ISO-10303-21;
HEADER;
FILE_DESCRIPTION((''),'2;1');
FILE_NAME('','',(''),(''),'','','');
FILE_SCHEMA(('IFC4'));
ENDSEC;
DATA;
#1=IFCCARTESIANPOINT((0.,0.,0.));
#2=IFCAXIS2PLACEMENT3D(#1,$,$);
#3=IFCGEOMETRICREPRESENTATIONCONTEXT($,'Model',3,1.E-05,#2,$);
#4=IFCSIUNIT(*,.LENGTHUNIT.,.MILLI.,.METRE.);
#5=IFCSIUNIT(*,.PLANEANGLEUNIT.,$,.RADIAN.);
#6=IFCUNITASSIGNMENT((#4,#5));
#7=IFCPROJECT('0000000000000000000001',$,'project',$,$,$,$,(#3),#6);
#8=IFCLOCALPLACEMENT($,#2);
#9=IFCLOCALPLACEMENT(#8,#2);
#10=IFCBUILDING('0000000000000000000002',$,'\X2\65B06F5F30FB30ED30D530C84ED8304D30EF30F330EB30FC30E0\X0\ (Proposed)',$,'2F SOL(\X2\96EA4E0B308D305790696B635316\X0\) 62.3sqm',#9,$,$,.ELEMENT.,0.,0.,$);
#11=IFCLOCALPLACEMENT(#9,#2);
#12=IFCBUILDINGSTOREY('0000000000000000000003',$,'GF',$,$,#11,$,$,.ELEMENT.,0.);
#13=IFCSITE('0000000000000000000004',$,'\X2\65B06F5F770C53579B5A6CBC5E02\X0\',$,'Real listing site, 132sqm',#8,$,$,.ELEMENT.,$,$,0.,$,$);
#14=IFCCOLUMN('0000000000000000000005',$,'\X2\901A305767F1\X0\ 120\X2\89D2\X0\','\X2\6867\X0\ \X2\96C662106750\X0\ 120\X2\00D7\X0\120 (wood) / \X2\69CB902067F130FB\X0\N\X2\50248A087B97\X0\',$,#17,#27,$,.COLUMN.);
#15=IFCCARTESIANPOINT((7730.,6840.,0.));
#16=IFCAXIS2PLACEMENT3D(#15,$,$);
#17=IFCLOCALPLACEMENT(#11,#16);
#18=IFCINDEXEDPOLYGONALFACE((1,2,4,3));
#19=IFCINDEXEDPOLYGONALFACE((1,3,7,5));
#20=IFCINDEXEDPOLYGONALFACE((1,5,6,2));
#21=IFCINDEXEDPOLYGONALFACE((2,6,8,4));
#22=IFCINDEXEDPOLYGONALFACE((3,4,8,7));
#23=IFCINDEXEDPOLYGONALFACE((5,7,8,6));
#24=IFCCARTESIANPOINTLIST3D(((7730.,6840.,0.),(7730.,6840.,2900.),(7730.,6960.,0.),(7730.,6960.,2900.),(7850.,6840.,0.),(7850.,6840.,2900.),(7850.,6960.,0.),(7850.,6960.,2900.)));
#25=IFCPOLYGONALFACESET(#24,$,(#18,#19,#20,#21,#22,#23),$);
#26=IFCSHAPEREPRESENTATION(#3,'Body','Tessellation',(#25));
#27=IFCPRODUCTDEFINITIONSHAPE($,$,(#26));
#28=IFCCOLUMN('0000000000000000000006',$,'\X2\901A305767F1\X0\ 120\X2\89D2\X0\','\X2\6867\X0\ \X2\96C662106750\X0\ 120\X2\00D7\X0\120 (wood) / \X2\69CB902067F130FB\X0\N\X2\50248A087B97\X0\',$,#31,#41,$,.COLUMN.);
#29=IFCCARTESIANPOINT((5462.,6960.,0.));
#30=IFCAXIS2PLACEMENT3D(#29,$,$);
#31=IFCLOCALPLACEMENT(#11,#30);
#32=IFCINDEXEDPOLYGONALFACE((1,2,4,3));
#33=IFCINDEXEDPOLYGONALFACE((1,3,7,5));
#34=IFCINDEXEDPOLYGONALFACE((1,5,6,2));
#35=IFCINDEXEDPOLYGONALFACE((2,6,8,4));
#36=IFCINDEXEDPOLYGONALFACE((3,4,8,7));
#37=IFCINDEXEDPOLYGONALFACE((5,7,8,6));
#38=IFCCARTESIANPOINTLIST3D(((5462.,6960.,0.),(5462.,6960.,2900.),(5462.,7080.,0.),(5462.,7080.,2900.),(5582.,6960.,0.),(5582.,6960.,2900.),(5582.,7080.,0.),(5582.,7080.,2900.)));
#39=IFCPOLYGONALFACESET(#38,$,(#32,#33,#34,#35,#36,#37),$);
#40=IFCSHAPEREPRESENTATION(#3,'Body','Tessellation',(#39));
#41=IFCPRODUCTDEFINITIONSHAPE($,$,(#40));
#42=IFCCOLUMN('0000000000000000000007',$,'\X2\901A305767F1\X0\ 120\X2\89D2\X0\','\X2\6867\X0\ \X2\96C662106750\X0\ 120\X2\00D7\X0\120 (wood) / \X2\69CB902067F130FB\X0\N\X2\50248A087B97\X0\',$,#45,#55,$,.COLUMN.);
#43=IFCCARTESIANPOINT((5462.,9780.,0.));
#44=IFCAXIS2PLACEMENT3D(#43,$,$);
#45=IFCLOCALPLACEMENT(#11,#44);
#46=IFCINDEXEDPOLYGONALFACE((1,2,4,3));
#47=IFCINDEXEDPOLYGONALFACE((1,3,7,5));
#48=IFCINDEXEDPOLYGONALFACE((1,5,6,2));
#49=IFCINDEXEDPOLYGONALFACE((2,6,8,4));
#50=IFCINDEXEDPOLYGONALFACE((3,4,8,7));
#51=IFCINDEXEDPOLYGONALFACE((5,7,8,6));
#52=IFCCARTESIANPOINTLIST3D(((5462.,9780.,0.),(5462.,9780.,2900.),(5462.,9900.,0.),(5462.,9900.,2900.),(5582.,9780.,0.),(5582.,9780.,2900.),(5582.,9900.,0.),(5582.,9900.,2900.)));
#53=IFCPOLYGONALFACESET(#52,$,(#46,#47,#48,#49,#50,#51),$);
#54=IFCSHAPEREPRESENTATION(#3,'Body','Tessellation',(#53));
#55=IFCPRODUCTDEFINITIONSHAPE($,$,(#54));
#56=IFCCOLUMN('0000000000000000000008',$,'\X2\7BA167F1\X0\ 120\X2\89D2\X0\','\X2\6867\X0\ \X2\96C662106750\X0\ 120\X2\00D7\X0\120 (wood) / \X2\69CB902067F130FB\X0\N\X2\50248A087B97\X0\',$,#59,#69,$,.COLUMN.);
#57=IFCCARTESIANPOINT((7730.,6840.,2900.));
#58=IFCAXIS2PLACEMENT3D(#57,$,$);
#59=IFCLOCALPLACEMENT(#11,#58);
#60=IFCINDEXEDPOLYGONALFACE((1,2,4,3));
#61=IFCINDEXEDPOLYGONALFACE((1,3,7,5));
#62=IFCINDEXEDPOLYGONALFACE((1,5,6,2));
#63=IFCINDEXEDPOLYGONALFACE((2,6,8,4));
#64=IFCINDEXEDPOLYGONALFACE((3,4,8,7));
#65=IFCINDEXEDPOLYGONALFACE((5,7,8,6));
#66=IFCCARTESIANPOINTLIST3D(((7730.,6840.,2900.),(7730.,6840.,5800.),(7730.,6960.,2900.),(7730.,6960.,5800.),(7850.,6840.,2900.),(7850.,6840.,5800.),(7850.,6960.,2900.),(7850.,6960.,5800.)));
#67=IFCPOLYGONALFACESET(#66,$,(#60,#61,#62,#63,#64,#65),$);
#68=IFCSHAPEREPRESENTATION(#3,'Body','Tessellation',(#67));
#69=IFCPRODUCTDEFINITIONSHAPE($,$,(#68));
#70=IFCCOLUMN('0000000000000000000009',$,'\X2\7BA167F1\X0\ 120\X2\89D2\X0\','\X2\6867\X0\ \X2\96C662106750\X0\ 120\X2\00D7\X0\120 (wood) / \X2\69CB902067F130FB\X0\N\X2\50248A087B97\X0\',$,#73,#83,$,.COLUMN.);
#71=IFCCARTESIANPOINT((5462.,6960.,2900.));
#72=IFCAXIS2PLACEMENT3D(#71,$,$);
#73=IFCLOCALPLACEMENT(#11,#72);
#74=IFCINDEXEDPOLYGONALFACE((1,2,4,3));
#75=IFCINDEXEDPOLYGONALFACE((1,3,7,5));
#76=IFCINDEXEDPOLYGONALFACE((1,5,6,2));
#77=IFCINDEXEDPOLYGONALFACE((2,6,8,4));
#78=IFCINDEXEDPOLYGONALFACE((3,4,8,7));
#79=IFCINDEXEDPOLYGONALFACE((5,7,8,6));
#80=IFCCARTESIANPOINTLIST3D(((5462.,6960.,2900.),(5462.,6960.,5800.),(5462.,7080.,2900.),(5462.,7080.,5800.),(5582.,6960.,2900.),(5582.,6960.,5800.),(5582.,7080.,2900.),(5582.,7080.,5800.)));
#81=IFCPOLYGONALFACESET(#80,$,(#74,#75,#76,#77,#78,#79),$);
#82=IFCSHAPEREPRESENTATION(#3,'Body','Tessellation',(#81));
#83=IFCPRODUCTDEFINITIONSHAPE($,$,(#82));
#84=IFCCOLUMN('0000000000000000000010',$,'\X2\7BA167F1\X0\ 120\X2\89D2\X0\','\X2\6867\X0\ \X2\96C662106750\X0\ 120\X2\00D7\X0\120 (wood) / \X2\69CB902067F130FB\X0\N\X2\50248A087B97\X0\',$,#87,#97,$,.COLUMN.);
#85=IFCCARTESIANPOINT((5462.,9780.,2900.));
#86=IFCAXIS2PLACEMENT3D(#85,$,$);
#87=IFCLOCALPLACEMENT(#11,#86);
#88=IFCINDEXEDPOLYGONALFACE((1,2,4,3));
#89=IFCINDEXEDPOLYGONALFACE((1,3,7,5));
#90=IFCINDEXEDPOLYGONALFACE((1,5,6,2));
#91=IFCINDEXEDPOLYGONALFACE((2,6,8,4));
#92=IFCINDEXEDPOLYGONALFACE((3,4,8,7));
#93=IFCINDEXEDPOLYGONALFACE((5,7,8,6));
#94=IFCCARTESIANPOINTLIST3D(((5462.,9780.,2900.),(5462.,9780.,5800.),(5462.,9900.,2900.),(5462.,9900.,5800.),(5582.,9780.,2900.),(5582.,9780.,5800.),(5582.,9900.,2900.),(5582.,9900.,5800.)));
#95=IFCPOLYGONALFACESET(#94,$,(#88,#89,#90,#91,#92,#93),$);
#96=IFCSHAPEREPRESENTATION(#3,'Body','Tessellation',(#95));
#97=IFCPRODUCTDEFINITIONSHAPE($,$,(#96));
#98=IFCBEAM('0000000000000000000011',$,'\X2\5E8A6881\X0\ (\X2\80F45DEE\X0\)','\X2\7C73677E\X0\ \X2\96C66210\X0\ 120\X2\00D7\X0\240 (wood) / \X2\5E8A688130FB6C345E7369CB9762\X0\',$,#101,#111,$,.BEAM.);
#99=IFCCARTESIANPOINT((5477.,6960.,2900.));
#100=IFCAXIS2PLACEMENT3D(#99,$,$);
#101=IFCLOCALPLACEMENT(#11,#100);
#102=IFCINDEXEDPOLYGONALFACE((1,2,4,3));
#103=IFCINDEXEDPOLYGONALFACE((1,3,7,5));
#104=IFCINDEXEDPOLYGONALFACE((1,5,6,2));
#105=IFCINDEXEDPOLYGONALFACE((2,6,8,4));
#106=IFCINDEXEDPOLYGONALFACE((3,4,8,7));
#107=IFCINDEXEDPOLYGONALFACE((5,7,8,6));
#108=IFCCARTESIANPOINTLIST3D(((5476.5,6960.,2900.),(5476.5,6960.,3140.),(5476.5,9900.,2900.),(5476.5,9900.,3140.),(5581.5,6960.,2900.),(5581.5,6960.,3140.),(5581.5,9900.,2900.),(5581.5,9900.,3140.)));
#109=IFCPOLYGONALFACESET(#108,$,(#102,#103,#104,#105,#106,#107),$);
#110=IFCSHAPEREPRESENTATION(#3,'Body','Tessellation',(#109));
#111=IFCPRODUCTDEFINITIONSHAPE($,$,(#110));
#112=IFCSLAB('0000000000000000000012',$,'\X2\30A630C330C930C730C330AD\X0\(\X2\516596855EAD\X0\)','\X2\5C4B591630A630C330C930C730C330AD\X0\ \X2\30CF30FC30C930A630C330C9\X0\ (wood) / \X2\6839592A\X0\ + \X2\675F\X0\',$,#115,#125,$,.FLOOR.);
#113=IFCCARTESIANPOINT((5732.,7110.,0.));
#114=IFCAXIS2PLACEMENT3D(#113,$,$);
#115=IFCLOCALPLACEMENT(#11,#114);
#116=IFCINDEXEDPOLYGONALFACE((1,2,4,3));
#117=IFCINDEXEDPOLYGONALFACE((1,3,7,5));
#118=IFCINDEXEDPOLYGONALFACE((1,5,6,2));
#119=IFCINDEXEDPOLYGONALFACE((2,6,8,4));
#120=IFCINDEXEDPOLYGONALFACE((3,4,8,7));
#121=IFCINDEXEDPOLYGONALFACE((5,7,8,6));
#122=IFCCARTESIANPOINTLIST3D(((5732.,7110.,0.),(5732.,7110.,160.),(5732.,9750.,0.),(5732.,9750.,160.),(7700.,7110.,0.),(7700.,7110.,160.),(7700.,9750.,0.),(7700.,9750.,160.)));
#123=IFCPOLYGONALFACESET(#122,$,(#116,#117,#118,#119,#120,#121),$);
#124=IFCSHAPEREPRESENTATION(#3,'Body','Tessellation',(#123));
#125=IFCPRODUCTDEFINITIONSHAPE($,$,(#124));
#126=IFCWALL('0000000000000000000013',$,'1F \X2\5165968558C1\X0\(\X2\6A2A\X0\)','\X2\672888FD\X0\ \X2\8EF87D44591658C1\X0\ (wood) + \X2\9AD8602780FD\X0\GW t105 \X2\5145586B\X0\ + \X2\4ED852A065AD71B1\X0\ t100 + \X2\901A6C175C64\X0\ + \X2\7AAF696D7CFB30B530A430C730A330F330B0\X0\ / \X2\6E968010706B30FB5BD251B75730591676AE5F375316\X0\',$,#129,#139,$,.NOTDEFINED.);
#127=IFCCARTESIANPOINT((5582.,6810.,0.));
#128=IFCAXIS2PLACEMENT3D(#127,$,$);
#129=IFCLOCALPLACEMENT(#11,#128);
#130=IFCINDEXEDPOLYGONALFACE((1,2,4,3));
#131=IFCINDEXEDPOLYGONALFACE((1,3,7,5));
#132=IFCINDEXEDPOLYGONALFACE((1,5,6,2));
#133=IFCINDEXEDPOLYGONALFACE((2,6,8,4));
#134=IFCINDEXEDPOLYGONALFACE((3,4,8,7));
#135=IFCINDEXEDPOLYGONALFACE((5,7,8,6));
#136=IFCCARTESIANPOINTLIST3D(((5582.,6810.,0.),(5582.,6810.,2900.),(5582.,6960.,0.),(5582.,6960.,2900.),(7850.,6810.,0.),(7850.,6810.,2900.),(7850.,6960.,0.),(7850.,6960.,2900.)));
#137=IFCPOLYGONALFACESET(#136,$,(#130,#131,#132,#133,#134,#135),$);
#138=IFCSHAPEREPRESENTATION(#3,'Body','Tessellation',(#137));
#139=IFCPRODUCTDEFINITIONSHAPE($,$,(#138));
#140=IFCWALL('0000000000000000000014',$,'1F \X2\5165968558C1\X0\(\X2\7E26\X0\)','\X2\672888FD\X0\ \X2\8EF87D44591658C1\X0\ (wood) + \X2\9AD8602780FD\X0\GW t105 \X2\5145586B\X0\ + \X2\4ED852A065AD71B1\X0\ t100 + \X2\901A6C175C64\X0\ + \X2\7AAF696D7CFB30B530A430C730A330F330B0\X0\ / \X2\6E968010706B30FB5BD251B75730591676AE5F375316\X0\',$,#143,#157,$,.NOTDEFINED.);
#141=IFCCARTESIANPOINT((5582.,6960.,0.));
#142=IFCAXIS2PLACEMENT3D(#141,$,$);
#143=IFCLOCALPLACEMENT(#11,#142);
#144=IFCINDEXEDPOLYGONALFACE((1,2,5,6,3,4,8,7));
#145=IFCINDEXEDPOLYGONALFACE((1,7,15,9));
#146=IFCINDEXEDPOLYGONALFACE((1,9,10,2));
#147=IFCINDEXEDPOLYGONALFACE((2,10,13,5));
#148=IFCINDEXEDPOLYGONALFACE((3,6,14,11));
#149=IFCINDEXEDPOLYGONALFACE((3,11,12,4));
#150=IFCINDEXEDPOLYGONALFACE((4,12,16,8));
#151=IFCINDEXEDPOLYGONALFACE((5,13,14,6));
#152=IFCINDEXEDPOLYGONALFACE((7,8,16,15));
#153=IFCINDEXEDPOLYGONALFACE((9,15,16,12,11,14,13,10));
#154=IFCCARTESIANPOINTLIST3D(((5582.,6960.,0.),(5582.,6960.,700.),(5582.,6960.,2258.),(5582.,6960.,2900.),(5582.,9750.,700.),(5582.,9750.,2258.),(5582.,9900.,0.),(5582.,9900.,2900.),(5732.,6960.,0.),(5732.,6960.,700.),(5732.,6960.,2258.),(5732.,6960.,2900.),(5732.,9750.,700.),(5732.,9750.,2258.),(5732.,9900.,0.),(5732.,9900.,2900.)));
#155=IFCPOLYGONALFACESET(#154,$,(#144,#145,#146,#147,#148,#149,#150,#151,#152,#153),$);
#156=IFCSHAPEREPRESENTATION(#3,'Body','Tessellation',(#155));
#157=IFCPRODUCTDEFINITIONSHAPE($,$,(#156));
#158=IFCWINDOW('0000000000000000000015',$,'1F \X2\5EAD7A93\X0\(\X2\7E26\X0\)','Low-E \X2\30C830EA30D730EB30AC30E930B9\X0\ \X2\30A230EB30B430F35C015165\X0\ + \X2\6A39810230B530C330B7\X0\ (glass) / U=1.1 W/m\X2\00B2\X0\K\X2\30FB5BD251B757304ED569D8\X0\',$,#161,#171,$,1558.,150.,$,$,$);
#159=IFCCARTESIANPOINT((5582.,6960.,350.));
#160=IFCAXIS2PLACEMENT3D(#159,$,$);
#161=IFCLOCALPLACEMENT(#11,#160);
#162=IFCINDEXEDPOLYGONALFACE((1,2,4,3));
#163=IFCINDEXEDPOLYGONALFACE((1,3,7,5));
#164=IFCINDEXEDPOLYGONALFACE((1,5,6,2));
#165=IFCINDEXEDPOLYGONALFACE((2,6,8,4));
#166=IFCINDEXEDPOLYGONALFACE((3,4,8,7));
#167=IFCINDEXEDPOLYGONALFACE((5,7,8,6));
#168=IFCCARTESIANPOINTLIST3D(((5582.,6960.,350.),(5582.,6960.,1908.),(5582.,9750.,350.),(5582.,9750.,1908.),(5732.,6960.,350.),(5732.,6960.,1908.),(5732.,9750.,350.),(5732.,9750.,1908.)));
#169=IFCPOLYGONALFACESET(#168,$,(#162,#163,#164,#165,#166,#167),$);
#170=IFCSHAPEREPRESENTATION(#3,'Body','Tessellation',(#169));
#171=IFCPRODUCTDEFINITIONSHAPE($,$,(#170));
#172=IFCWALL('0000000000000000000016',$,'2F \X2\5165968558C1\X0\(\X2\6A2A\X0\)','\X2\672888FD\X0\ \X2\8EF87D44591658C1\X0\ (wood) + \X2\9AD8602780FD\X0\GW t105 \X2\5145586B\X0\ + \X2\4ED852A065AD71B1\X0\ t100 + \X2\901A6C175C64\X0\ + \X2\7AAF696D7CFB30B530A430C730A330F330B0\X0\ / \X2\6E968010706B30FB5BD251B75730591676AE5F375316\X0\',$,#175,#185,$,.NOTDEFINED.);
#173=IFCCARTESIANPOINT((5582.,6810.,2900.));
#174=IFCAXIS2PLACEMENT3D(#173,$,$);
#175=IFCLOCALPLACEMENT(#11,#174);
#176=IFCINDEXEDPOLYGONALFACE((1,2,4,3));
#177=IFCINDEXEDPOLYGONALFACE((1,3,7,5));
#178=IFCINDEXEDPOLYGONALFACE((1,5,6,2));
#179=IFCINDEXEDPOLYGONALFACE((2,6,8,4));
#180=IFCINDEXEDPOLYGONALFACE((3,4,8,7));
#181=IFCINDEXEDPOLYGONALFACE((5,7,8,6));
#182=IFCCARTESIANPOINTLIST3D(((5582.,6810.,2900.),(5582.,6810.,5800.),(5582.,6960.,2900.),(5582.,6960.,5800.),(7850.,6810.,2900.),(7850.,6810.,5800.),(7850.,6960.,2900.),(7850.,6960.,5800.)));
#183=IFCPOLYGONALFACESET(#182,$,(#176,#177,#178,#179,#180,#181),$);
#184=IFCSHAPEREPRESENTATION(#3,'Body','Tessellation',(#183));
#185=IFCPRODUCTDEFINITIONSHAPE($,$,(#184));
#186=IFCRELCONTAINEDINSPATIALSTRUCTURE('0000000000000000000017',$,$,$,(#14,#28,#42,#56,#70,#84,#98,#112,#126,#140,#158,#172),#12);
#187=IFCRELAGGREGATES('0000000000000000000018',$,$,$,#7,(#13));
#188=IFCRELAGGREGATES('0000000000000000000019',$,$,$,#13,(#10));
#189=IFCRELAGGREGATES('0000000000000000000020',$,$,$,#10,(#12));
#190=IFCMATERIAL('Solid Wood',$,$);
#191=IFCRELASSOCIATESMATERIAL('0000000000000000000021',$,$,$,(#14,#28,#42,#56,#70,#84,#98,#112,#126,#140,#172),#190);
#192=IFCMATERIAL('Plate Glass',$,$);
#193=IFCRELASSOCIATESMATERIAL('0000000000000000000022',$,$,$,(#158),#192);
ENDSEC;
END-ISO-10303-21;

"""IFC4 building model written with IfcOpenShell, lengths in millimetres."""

from ifc_helpers import new_model, si_unit, frame, frame_2d, origin, place, context, project, spatial, rectangle, extrude, material, element, fill, save


model = new_model("IFC4")

# Units and contexts
model_context = context("Model", 3, precision=1e-05, world=origin())
ifc_project = project(units=[si_unit("LENGTHUNIT", "METRE", prefix="MILLI"), si_unit("PLANEANGLEUNIT", "RADIAN")], contexts=[model_context])

# Site, building, storey
site_placement = place(None, origin())
site = spatial("IfcSite", under=ifc_project, at=site_placement, Name="新潟県南魚沼市", ObjectType="Real listing site, 132sqm", CompositionType="ELEMENT", RefElevation=0.0)
building_placement = place(site_placement, origin())
building = spatial("IfcBuilding", under=site, at=building_placement, Name="新潟・ロフト付きワンルーム (Proposed)", ObjectType="2F SOL(雪下ろし適正化) 62.3sqm", CompositionType="ELEMENT", ElevationOfRefHeight=0.0, ElevationOfTerrain=0.0)
storey_placement = place(building_placement, origin())
storey = spatial("IfcBuildingStorey", under=building, at=storey_placement, Name="GF", CompositionType="ELEMENT", Elevation=0.0)

# Columns
ifc_material_1 = material(Name="Solid Wood")
column_1_placement = place(storey_placement, frame((7730.0, 6840.0, 0.0)))
element("IfcColumn", 1, at=column_1_placement, inside=storey, material=ifc_material_1, Name="通し柱 120角", Description="桧 集成材 120×120 (wood) / 構造柱・N値計算", PredefinedType="COLUMN", context=model_context, shape_type="SweptSolid", body=[
    extrude(rectangle(XDim=120.0, YDim=120.0, at=frame_2d((60.0, 60.0))), frame((7730.0, 6840.0, 0.0)), (0.0, 0.0, 1.0), 2900.0),
])
column_2_placement = place(storey_placement, frame((5462.0, 6960.0, 0.0)))
element("IfcColumn", 2, at=column_2_placement, inside=storey, material=ifc_material_1, Name="通し柱 120角", Description="桧 集成材 120×120 (wood) / 構造柱・N値計算", PredefinedType="COLUMN", context=model_context, shape_type="SweptSolid", body=[
    extrude(rectangle(XDim=120.0, YDim=120.0, at=frame_2d((60.0, 60.0))), frame((5462.0, 6960.0, 0.0)), (0.0, 0.0, 1.0), 2900.0),
])
column_3_placement = place(storey_placement, frame((5462.0, 9780.0, 0.0)))
element("IfcColumn", 3, at=column_3_placement, inside=storey, material=ifc_material_1, Name="通し柱 120角", Description="桧 集成材 120×120 (wood) / 構造柱・N値計算", PredefinedType="COLUMN", context=model_context, shape_type="SweptSolid", body=[
    extrude(rectangle(XDim=120.0, YDim=120.0, at=frame_2d((60.0, 60.0))), frame((5462.0, 9780.0, 0.0)), (0.0, 0.0, 1.0), 2900.0),
])
column_4_placement = place(storey_placement, frame((7730.0, 6840.0, 2900.0)))
element("IfcColumn", 4, at=column_4_placement, inside=storey, material=ifc_material_1, Name="管柱 120角", Description="桧 集成材 120×120 (wood) / 構造柱・N値計算", PredefinedType="COLUMN", context=model_context, shape_type="SweptSolid", body=[
    extrude(rectangle(XDim=120.0, YDim=120.0, at=frame_2d((60.0, 60.0))), frame((7730.0, 6840.0, 2900.0)), (0.0, 0.0, 1.0), 2900.0),
])
column_5_placement = place(storey_placement, frame((5462.0, 6960.0, 2900.0)))
element("IfcColumn", 5, at=column_5_placement, inside=storey, material=ifc_material_1, Name="管柱 120角", Description="桧 集成材 120×120 (wood) / 構造柱・N値計算", PredefinedType="COLUMN", context=model_context, shape_type="SweptSolid", body=[
    extrude(rectangle(XDim=120.0, YDim=120.0, at=frame_2d((60.0, 60.0))), frame((5462.0, 6960.0, 2900.0)), (0.0, 0.0, 1.0), 2900.0),
])
column_6_placement = place(storey_placement, frame((5462.0, 9780.0, 2900.0)))
element("IfcColumn", 6, at=column_6_placement, inside=storey, material=ifc_material_1, Name="管柱 120角", Description="桧 集成材 120×120 (wood) / 構造柱・N値計算", PredefinedType="COLUMN", context=model_context, shape_type="SweptSolid", body=[
    extrude(rectangle(XDim=120.0, YDim=120.0, at=frame_2d((60.0, 60.0))), frame((5462.0, 9780.0, 2900.0)), (0.0, 0.0, 1.0), 2900.0),
])

# Beam
beam_1_placement = place(storey_placement, frame((5477.0, 6960.0, 2900.0)))
element("IfcBeam", 7, at=beam_1_placement, inside=storey, material=ifc_material_1, Name="床梁 (胴差)", Description="米松 集成 120×240 (wood) / 床梁・水平構面", PredefinedType="BEAM", context=model_context, shape_type="SweptSolid", body=[
    extrude(rectangle(XDim=105.0, YDim=2940.0, at=frame_2d((52.0, 1470.0))), frame((5477.0, 6960.0, 2900.0)), (0.0, 0.0, 1.0), 240.0),
])

# Slab
slab_placement = place(storey_placement, frame((5732.0, 7110.0, 0.0)))
element("IfcSlab", 8, at=slab_placement, inside=storey, material=ifc_material_1, Name="ウッドデッキ(入隅庭)", Description="屋外ウッドデッキ ハードウッド (wood) / 根太 + 束", PredefinedType="FLOOR", context=model_context, shape_type="SweptSolid", body=[
    extrude(rectangle(XDim=1968.0, YDim=2640.0, at=frame_2d((984.0, 1320.0))), frame((5732.0, 7110.0, 0.0)), (0.0, 0.0, 1.0), 160.0),
])

# Wall
wall_1_placement = place(storey_placement, frame((5582.0, 6810.0, 0.0)))
element("IfcWall", 9, at=wall_1_placement, inside=storey, material=ifc_material_1, Name="1F 入隅壁(横)", Description="木製 軸組外壁 (wood) + 高性能GW t105 充填 + 付加断熱 t100 + 通気層 + 窯業系サイディング / 準耐火・寒冷地外皮強化", PredefinedType="NOTDEFINED", context=model_context, shape_type="SweptSolid", body=[
    extrude(rectangle(XDim=2268.0, YDim=150.0, at=frame_2d((1134.0, 75.0))), frame((5582.0, 6810.0, 0.0)), (0.0, 0.0, 1.0), 2900.0),
])

# Wall, opening, window
wall_2_placement = place(storey_placement, frame((5582.0, 6960.0, 0.0)))
wall_2 = element("IfcWall", 10, at=wall_2_placement, inside=storey, material=ifc_material_1, Name="1F 入隅壁(縦)", Description="木製 軸組外壁 (wood) + 高性能GW t105 充填 + 付加断熱 t100 + 通気層 + 窯業系サイディング / 準耐火・寒冷地外皮強化", PredefinedType="NOTDEFINED", context=model_context, shape_type="SweptSolid", body=[
    extrude(rectangle(XDim=150.0, YDim=2940.0, at=frame_2d((75.0, 1470.0))), frame((5582.0, 6960.0, 0.0)), (0.0, 0.0, 1.0), 2900.0),
])
opening_1_placement = place(storey_placement, frame((5582.0, 6960.0, 350.0)))
opening_1 = element("IfcOpeningElement", 11, at=opening_1_placement, cuts=wall_2, PredefinedType="NOTDEFINED", context=model_context, shape_type="SweptSolid", body=[
    extrude(rectangle(XDim=150.0, YDim=2790.0, at=frame_2d((75.0, 1395.0))), frame((5582.0, 6960.0, 350.0)), (0.0, 0.0, 1.0), 1558.0),
])
ifc_material_2 = material(Name="Plate Glass")
window_1_placement = place(storey_placement, frame((5582.0, 6960.0, 350.0)))
window_1 = element("IfcWindow", 12, at=window_1_placement, inside=storey, material=ifc_material_2, Name="1F 庭窓(縦)", Description="Low-E トリプルガラス アルゴン封入 + 樹脂サッシ (glass) / U=1.1 W/m²K・寒冷地仕様", OverallHeight=1558.0, OverallWidth=150.0, context=model_context, shape_type="SweptSolid", body=[
    extrude(rectangle(XDim=150.0, YDim=2790.0, at=frame_2d((75.0, 1395.0))), frame((5582.0, 6960.0, 350.0)), (0.0, 0.0, 1.0), 1558.0),
])
fill(opening_1, window_1)

# Wall
wall_3_placement = place(storey_placement, frame((5582.0, 6810.0, 2900.0)))
element("IfcWall", 13, at=wall_3_placement, inside=storey, material=ifc_material_1, Name="2F 入隅壁(横)", Description="木製 軸組外壁 (wood) + 高性能GW t105 充填 + 付加断熱 t100 + 通気層 + 窯業系サイディング / 準耐火・寒冷地外皮強化", PredefinedType="NOTDEFINED", context=model_context, shape_type="SweptSolid", body=[
    extrude(rectangle(XDim=2268.0, YDim=150.0, at=frame_2d((1134.0, 75.0))), frame((5582.0, 6810.0, 2900.0)), (0.0, 0.0, 1.0), 2900.0),
])

save(model, "model.ifc")
